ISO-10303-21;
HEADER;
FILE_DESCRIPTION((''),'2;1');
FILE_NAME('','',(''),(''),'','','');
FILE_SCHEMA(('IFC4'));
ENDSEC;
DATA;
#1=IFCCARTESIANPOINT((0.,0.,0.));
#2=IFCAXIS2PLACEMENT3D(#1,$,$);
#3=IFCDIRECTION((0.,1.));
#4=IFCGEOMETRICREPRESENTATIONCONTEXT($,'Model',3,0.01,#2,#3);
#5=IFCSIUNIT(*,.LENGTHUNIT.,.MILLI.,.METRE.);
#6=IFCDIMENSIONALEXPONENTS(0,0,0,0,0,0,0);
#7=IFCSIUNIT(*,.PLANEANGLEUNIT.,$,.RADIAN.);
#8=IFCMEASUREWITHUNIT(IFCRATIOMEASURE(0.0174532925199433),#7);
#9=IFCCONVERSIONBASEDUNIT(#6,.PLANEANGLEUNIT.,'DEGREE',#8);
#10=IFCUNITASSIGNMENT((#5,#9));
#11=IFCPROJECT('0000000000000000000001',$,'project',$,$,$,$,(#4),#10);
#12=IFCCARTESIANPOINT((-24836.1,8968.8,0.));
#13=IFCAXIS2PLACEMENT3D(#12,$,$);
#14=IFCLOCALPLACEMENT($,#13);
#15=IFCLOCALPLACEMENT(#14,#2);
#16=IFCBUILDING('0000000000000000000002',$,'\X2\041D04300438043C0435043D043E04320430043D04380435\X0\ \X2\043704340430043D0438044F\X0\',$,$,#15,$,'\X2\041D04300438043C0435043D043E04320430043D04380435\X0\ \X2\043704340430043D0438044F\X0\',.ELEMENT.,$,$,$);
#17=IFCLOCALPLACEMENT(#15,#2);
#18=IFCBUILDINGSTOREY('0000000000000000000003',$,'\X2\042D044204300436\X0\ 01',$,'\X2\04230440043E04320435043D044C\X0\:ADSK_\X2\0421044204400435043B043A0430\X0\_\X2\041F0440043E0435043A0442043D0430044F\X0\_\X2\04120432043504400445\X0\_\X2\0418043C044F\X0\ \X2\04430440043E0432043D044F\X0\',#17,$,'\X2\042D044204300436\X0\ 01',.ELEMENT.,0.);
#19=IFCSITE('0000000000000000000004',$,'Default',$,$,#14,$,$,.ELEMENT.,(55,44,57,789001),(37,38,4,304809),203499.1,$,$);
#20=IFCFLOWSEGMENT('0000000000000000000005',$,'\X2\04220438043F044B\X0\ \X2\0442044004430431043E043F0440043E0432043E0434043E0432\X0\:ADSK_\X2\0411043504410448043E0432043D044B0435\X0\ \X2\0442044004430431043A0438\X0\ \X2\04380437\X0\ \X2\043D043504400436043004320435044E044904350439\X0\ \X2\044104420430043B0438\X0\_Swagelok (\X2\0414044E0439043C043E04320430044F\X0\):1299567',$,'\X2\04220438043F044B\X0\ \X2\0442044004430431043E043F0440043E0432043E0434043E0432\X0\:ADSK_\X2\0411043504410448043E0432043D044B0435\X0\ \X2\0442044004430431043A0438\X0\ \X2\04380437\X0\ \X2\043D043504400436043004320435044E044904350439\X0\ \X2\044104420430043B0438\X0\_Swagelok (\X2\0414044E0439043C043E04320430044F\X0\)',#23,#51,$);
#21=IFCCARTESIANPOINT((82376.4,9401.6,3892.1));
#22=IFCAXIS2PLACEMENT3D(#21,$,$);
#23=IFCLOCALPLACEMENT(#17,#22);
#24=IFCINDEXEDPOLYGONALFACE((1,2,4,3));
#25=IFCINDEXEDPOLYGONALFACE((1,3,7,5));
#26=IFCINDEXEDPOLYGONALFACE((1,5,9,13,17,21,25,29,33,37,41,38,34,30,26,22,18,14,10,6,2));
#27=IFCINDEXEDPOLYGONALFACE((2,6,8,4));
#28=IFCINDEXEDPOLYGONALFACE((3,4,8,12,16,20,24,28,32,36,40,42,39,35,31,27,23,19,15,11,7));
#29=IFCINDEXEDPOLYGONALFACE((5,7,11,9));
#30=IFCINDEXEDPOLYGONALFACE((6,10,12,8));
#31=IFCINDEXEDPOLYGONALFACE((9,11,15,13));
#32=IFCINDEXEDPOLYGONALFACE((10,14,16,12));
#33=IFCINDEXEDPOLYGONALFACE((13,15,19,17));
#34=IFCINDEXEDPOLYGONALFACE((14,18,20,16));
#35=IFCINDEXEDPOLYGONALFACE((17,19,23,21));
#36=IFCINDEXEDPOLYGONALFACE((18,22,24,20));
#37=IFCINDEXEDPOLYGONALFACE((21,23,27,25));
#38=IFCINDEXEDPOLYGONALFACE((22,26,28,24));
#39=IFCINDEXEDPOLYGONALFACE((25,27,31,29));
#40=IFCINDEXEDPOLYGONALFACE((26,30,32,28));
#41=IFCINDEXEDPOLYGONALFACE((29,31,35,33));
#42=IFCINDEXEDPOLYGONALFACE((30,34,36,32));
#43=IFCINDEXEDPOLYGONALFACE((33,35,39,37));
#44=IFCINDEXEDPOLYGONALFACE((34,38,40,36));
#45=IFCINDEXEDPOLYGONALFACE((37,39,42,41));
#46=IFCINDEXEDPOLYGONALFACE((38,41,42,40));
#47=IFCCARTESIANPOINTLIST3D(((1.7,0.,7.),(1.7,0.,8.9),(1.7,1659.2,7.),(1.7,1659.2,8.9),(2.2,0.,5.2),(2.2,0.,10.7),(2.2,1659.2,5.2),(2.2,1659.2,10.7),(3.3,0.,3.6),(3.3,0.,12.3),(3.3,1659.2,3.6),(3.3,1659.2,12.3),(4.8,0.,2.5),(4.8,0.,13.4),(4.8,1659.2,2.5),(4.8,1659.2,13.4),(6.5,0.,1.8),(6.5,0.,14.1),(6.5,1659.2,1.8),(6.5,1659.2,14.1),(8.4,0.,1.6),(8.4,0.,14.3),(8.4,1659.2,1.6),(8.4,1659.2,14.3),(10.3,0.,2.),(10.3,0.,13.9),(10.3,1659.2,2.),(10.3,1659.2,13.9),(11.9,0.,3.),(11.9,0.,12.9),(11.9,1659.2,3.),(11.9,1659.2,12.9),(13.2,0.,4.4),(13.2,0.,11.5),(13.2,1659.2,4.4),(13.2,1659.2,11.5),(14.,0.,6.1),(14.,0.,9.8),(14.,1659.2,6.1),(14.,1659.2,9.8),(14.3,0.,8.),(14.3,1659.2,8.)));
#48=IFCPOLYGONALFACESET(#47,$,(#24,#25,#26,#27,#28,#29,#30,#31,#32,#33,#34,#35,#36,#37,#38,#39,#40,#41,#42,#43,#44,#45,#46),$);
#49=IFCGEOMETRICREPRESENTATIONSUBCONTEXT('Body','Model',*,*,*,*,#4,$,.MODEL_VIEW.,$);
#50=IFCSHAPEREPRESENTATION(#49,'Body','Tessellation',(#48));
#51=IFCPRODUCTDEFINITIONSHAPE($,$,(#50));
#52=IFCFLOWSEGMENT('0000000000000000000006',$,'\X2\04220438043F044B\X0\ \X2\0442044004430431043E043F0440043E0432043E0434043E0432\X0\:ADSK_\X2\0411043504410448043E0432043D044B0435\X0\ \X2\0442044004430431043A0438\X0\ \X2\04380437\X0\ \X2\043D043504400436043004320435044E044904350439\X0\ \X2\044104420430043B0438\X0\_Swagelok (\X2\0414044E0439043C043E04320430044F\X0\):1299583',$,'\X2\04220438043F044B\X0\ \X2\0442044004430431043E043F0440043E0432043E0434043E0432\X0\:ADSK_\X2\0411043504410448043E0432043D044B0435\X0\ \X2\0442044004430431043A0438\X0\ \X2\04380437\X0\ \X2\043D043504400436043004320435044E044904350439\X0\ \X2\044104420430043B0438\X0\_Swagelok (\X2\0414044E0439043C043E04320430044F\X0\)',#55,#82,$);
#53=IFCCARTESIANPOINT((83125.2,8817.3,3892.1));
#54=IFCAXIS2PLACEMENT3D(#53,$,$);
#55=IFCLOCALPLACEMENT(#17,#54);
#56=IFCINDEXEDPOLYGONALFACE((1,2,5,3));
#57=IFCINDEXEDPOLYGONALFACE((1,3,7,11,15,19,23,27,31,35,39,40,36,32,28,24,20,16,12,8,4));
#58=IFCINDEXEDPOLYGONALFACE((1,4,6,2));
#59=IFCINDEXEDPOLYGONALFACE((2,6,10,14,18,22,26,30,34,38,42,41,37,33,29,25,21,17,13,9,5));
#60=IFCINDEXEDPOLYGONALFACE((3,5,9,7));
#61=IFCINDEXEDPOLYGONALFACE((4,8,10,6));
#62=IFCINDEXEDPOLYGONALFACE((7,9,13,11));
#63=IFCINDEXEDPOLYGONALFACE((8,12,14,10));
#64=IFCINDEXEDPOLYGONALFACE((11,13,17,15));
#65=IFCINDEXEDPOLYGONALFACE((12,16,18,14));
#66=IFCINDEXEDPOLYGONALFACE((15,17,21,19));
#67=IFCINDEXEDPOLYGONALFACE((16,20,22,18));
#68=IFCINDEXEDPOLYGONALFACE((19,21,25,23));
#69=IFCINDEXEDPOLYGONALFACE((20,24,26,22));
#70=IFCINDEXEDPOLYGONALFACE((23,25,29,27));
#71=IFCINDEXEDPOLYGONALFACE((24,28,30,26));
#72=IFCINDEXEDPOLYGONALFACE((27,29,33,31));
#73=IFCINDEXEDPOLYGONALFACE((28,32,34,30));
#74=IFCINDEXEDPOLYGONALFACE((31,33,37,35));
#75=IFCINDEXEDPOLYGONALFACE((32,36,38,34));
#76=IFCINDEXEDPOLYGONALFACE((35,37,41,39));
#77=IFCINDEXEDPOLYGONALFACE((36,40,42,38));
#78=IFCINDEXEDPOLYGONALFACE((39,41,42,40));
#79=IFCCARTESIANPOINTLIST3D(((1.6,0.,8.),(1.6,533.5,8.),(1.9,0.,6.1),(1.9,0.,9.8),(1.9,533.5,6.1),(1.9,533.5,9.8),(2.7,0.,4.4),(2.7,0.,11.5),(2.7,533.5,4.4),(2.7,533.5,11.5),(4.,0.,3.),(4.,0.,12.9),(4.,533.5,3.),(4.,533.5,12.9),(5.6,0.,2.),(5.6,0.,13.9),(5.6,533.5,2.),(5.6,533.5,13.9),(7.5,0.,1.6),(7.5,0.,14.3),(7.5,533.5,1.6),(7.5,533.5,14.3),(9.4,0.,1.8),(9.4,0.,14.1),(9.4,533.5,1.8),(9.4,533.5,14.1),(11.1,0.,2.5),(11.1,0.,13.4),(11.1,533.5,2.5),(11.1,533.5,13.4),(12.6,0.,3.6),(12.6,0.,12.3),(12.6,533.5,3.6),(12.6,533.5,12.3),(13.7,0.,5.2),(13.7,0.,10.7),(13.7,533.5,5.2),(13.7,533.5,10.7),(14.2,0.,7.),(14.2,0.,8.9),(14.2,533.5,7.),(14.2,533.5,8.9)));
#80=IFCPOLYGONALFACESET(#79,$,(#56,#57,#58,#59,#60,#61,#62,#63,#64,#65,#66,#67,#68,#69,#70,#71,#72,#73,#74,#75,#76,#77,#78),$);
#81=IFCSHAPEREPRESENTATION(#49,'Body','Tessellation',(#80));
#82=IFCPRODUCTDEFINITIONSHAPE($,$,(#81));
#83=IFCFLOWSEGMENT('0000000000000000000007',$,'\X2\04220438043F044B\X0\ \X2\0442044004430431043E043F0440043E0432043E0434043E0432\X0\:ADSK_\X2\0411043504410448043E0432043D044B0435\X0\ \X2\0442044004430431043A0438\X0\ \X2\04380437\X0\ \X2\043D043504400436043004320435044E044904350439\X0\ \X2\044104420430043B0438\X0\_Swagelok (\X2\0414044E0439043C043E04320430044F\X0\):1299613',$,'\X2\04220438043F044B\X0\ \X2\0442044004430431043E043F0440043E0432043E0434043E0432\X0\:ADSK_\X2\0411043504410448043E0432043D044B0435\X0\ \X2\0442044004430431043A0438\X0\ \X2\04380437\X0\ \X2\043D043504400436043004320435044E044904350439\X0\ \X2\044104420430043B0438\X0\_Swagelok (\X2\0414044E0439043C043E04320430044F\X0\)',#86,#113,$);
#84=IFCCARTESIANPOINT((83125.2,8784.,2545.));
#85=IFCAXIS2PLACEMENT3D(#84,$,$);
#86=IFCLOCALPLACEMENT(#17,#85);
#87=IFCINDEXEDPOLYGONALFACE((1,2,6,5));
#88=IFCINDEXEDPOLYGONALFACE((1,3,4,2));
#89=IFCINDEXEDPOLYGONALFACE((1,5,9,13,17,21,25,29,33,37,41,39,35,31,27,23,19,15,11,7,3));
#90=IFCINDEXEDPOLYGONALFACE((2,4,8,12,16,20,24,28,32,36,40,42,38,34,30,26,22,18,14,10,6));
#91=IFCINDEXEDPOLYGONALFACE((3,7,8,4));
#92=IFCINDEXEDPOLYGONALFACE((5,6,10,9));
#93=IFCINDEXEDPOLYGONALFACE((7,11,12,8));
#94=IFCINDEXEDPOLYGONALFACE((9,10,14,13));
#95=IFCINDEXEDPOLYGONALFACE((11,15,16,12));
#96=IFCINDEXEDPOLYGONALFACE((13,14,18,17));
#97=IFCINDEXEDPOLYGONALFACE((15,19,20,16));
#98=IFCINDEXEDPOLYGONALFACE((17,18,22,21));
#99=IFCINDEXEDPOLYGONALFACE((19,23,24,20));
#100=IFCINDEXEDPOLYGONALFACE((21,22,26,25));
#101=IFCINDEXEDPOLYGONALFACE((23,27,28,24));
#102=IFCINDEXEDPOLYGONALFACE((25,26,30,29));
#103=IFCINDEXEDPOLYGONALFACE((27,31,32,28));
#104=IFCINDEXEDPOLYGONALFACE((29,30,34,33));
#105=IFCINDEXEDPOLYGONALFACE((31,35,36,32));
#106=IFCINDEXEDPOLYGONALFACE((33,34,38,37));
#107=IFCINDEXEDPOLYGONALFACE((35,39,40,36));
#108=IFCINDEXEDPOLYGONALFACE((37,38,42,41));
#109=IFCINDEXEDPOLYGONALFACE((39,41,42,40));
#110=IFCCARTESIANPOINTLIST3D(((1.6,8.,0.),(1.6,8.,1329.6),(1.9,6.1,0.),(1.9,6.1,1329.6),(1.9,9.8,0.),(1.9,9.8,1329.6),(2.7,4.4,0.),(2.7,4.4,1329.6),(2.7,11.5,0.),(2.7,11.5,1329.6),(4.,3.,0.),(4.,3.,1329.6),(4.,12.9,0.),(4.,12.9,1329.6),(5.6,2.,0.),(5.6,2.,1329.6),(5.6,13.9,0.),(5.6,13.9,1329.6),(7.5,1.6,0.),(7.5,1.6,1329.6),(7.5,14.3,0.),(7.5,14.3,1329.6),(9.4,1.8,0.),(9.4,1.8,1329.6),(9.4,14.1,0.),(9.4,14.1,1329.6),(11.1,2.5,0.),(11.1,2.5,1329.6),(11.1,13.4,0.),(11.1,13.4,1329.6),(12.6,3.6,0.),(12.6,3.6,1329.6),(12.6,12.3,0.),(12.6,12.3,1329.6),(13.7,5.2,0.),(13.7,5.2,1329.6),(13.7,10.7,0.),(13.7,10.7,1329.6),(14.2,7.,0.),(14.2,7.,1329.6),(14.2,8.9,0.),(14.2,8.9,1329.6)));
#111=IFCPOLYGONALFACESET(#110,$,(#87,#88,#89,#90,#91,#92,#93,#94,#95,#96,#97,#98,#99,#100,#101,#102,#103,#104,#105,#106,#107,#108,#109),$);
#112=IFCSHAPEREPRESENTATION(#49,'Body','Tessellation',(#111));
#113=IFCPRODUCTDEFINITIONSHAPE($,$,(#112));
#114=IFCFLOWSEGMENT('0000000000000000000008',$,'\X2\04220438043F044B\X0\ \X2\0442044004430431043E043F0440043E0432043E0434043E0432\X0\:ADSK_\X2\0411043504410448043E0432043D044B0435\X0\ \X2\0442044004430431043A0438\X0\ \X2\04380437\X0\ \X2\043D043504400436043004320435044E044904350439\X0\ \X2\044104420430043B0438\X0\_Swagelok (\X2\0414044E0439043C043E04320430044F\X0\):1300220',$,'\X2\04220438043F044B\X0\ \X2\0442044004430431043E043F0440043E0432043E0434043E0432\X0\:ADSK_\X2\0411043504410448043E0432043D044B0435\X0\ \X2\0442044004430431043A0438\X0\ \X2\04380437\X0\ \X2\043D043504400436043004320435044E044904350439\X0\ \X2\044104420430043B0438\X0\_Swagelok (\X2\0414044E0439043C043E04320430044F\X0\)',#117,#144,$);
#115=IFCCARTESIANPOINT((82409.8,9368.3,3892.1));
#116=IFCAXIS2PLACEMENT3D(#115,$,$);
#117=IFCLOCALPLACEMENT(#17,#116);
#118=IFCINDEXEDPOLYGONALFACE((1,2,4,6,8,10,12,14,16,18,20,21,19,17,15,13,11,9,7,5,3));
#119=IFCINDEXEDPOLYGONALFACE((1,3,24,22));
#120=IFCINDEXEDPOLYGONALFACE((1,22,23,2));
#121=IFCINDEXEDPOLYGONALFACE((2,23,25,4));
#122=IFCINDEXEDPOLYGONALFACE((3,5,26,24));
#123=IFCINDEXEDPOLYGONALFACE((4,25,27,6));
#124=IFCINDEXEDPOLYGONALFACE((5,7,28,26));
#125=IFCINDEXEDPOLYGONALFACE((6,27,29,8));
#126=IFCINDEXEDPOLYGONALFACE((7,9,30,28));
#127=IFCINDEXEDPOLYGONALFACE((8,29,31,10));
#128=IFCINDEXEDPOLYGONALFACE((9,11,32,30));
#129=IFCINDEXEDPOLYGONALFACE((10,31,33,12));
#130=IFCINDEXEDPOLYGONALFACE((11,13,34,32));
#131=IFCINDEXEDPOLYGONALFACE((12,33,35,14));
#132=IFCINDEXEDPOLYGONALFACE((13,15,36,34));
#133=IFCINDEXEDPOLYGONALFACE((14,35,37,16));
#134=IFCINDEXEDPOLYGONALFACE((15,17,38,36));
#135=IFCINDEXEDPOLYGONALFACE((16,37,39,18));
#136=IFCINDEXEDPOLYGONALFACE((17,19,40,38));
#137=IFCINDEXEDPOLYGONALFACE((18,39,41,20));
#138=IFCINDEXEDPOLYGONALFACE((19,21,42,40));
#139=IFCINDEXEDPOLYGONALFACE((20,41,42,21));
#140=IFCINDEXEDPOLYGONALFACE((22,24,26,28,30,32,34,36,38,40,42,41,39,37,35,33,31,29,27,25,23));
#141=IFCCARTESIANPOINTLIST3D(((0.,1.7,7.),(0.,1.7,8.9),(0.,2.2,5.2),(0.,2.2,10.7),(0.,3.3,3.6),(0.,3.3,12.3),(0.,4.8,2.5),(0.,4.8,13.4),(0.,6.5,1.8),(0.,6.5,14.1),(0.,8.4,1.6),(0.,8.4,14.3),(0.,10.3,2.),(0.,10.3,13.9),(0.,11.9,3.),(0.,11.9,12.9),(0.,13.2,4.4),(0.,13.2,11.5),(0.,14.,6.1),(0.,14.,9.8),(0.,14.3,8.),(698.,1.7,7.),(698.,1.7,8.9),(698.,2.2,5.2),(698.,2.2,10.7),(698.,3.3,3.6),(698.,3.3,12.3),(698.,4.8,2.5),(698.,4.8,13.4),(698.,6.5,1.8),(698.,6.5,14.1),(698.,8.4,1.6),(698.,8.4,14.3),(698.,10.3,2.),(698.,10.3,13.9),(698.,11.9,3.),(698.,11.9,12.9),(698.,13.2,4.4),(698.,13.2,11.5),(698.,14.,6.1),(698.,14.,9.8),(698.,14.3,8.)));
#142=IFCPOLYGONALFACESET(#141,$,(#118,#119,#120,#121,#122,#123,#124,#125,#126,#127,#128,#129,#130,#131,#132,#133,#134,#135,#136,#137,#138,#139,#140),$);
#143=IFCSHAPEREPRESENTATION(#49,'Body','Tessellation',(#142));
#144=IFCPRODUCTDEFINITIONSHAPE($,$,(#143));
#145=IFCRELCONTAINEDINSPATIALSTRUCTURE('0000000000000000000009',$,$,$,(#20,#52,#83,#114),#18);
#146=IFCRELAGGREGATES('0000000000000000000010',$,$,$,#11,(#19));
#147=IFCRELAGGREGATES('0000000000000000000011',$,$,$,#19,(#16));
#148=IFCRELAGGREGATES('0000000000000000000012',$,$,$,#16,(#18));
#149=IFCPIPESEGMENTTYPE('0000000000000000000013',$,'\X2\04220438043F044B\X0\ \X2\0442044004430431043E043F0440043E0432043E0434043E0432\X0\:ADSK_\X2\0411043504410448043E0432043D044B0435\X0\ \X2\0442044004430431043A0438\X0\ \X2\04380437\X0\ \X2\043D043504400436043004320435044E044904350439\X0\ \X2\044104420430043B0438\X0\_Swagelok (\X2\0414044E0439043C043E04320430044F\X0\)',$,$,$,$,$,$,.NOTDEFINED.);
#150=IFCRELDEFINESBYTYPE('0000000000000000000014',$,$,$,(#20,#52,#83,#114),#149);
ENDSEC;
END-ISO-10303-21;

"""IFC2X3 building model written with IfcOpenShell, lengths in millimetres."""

from ifc_helpers import new_model, entity, si_unit, converted_unit, direction, frame, origin, origin_2d_with_axis, place, context, subcontext, project, spatial, circle, extrude, type_object, element, save


model = new_model("IFC2X3")

# Units and contexts
model_context = context("Model", 3, precision=0.01, world=origin(), true_north=direction((0.0, 1.0)))
body_context = subcontext(model_context, "Body", "Model", "MODEL_VIEW")
ifc_project = project(units=[si_unit("LENGTHUNIT", "METRE", prefix="MILLI"), converted_unit("PLANEANGLEUNIT", "DEGREE", entity("IfcRatioMeasure", 0.0174532925199433), si_unit("PLANEANGLEUNIT", "RADIAN"), dimensions=[0, 0, 0, 0, 0, 0, 0])], contexts=[model_context])

# Site, building, storey
site_placement = place(None, frame((-24836.1, 8968.8, 0.0)))
site = spatial("IfcSite", under=ifc_project, at=site_placement, Name="Default", CompositionType="ELEMENT", RefLatitude=(55, 44, 57, 789001), RefLongitude=(37, 38, 4, 304809), RefElevation=203499.1)
building_placement = place(site_placement, origin())
building = spatial("IfcBuilding", under=site, at=building_placement, Name="Наименование здания", LongName="Наименование здания", CompositionType="ELEMENT")
storey_placement = place(building_placement, origin())
storey = spatial("IfcBuildingStorey", under=building, at=storey_placement, Name="Этаж 01", ObjectType="Уровень:ADSK_Стрелка_Проектная_Вверх_Имя уровня", LongName="Этаж 01", CompositionType="ELEMENT", Elevation=0.0)

# Flow segments
pipe_segment_type = type_object("IfcPipeSegmentType", Name="Типы трубопроводов:ADSK_Бесшовные трубки из нержавеющей стали_Swagelok (Дюймовая)", PredefinedType="NOTDEFINED")
flow_segment_1_placement = place(storey_placement, frame((82376.4, 9401.6, 3892.1)))
element("IfcFlowSegment", 1, at=flow_segment_1_placement, inside=storey, type_object=pipe_segment_type, Name="Типы трубопроводов:ADSK_Бесшовные трубки из нержавеющей стали_Swagelok (Дюймовая):1299567", ObjectType="Типы трубопроводов:ADSK_Бесшовные трубки из нержавеющей стали_Swagelok (Дюймовая)", context=body_context, shape_type="SweptSolid", body=[
    extrude(circle(Radius=6.3, at=origin_2d_with_axis()), frame((8.0, 0.0, 8.0), z_axis=(0.0, 1.0, 0.0), x_axis=(1.0, 0.0, 0.0)), (0.0, 0.0, 1.0), 1659.2),
])
flow_segment_2_placement = place(storey_placement, frame((83125.2, 8817.3, 3892.1)))
element("IfcFlowSegment", 2, at=flow_segment_2_placement, inside=storey, type_object=pipe_segment_type, Name="Типы трубопроводов:ADSK_Бесшовные трубки из нержавеющей стали_Swagelok (Дюймовая):1299583", ObjectType="Типы трубопроводов:ADSK_Бесшовные трубки из нержавеющей стали_Swagelok (Дюймовая)", context=body_context, shape_type="SweptSolid", body=[
    extrude(circle(Radius=6.3, at=origin_2d_with_axis()), frame((8.0, 0.0, 8.0), z_axis=(0.0, 1.0, 0.0), x_axis=(-1.0, 0.0, 0.0)), (0.0, 0.0, 1.0), 533.5),
])
flow_segment_3_placement = place(storey_placement, frame((83125.2, 8784.0, 2545.0)))
element("IfcFlowSegment", 3, at=flow_segment_3_placement, inside=storey, type_object=pipe_segment_type, Name="Типы трубопроводов:ADSK_Бесшовные трубки из нержавеющей стали_Swagelok (Дюймовая):1299613", ObjectType="Типы трубопроводов:ADSK_Бесшовные трубки из нержавеющей стали_Swagelok (Дюймовая)", context=body_context, shape_type="SweptSolid", body=[
    extrude(circle(Radius=6.3, at=origin_2d_with_axis()), frame((8.0, 8.0, 0.0), z_axis=(0.0, 0.0, 1.0), x_axis=(-1.0, 0.0, 0.0)), (0.0, 0.0, 1.0), 1329.6),
])
flow_segment_4_placement = place(storey_placement, frame((82409.8, 9368.3, 3892.1)))
element("IfcFlowSegment", 4, at=flow_segment_4_placement, inside=storey, type_object=pipe_segment_type, Name="Типы трубопроводов:ADSK_Бесшовные трубки из нержавеющей стали_Swagelok (Дюймовая):1300220", ObjectType="Типы трубопроводов:ADSK_Бесшовные трубки из нержавеющей стали_Swagelok (Дюймовая)", context=body_context, shape_type="SweptSolid", body=[
    extrude(circle(Radius=6.3, at=origin_2d_with_axis()), frame((0.0, 8.0, 8.0), z_axis=(1.0, 0.0, 0.0), x_axis=(0.0, 1.0, 0.0)), (0.0, 0.0, 1.0), 698.0),
])

save(model, "model.ifc")
